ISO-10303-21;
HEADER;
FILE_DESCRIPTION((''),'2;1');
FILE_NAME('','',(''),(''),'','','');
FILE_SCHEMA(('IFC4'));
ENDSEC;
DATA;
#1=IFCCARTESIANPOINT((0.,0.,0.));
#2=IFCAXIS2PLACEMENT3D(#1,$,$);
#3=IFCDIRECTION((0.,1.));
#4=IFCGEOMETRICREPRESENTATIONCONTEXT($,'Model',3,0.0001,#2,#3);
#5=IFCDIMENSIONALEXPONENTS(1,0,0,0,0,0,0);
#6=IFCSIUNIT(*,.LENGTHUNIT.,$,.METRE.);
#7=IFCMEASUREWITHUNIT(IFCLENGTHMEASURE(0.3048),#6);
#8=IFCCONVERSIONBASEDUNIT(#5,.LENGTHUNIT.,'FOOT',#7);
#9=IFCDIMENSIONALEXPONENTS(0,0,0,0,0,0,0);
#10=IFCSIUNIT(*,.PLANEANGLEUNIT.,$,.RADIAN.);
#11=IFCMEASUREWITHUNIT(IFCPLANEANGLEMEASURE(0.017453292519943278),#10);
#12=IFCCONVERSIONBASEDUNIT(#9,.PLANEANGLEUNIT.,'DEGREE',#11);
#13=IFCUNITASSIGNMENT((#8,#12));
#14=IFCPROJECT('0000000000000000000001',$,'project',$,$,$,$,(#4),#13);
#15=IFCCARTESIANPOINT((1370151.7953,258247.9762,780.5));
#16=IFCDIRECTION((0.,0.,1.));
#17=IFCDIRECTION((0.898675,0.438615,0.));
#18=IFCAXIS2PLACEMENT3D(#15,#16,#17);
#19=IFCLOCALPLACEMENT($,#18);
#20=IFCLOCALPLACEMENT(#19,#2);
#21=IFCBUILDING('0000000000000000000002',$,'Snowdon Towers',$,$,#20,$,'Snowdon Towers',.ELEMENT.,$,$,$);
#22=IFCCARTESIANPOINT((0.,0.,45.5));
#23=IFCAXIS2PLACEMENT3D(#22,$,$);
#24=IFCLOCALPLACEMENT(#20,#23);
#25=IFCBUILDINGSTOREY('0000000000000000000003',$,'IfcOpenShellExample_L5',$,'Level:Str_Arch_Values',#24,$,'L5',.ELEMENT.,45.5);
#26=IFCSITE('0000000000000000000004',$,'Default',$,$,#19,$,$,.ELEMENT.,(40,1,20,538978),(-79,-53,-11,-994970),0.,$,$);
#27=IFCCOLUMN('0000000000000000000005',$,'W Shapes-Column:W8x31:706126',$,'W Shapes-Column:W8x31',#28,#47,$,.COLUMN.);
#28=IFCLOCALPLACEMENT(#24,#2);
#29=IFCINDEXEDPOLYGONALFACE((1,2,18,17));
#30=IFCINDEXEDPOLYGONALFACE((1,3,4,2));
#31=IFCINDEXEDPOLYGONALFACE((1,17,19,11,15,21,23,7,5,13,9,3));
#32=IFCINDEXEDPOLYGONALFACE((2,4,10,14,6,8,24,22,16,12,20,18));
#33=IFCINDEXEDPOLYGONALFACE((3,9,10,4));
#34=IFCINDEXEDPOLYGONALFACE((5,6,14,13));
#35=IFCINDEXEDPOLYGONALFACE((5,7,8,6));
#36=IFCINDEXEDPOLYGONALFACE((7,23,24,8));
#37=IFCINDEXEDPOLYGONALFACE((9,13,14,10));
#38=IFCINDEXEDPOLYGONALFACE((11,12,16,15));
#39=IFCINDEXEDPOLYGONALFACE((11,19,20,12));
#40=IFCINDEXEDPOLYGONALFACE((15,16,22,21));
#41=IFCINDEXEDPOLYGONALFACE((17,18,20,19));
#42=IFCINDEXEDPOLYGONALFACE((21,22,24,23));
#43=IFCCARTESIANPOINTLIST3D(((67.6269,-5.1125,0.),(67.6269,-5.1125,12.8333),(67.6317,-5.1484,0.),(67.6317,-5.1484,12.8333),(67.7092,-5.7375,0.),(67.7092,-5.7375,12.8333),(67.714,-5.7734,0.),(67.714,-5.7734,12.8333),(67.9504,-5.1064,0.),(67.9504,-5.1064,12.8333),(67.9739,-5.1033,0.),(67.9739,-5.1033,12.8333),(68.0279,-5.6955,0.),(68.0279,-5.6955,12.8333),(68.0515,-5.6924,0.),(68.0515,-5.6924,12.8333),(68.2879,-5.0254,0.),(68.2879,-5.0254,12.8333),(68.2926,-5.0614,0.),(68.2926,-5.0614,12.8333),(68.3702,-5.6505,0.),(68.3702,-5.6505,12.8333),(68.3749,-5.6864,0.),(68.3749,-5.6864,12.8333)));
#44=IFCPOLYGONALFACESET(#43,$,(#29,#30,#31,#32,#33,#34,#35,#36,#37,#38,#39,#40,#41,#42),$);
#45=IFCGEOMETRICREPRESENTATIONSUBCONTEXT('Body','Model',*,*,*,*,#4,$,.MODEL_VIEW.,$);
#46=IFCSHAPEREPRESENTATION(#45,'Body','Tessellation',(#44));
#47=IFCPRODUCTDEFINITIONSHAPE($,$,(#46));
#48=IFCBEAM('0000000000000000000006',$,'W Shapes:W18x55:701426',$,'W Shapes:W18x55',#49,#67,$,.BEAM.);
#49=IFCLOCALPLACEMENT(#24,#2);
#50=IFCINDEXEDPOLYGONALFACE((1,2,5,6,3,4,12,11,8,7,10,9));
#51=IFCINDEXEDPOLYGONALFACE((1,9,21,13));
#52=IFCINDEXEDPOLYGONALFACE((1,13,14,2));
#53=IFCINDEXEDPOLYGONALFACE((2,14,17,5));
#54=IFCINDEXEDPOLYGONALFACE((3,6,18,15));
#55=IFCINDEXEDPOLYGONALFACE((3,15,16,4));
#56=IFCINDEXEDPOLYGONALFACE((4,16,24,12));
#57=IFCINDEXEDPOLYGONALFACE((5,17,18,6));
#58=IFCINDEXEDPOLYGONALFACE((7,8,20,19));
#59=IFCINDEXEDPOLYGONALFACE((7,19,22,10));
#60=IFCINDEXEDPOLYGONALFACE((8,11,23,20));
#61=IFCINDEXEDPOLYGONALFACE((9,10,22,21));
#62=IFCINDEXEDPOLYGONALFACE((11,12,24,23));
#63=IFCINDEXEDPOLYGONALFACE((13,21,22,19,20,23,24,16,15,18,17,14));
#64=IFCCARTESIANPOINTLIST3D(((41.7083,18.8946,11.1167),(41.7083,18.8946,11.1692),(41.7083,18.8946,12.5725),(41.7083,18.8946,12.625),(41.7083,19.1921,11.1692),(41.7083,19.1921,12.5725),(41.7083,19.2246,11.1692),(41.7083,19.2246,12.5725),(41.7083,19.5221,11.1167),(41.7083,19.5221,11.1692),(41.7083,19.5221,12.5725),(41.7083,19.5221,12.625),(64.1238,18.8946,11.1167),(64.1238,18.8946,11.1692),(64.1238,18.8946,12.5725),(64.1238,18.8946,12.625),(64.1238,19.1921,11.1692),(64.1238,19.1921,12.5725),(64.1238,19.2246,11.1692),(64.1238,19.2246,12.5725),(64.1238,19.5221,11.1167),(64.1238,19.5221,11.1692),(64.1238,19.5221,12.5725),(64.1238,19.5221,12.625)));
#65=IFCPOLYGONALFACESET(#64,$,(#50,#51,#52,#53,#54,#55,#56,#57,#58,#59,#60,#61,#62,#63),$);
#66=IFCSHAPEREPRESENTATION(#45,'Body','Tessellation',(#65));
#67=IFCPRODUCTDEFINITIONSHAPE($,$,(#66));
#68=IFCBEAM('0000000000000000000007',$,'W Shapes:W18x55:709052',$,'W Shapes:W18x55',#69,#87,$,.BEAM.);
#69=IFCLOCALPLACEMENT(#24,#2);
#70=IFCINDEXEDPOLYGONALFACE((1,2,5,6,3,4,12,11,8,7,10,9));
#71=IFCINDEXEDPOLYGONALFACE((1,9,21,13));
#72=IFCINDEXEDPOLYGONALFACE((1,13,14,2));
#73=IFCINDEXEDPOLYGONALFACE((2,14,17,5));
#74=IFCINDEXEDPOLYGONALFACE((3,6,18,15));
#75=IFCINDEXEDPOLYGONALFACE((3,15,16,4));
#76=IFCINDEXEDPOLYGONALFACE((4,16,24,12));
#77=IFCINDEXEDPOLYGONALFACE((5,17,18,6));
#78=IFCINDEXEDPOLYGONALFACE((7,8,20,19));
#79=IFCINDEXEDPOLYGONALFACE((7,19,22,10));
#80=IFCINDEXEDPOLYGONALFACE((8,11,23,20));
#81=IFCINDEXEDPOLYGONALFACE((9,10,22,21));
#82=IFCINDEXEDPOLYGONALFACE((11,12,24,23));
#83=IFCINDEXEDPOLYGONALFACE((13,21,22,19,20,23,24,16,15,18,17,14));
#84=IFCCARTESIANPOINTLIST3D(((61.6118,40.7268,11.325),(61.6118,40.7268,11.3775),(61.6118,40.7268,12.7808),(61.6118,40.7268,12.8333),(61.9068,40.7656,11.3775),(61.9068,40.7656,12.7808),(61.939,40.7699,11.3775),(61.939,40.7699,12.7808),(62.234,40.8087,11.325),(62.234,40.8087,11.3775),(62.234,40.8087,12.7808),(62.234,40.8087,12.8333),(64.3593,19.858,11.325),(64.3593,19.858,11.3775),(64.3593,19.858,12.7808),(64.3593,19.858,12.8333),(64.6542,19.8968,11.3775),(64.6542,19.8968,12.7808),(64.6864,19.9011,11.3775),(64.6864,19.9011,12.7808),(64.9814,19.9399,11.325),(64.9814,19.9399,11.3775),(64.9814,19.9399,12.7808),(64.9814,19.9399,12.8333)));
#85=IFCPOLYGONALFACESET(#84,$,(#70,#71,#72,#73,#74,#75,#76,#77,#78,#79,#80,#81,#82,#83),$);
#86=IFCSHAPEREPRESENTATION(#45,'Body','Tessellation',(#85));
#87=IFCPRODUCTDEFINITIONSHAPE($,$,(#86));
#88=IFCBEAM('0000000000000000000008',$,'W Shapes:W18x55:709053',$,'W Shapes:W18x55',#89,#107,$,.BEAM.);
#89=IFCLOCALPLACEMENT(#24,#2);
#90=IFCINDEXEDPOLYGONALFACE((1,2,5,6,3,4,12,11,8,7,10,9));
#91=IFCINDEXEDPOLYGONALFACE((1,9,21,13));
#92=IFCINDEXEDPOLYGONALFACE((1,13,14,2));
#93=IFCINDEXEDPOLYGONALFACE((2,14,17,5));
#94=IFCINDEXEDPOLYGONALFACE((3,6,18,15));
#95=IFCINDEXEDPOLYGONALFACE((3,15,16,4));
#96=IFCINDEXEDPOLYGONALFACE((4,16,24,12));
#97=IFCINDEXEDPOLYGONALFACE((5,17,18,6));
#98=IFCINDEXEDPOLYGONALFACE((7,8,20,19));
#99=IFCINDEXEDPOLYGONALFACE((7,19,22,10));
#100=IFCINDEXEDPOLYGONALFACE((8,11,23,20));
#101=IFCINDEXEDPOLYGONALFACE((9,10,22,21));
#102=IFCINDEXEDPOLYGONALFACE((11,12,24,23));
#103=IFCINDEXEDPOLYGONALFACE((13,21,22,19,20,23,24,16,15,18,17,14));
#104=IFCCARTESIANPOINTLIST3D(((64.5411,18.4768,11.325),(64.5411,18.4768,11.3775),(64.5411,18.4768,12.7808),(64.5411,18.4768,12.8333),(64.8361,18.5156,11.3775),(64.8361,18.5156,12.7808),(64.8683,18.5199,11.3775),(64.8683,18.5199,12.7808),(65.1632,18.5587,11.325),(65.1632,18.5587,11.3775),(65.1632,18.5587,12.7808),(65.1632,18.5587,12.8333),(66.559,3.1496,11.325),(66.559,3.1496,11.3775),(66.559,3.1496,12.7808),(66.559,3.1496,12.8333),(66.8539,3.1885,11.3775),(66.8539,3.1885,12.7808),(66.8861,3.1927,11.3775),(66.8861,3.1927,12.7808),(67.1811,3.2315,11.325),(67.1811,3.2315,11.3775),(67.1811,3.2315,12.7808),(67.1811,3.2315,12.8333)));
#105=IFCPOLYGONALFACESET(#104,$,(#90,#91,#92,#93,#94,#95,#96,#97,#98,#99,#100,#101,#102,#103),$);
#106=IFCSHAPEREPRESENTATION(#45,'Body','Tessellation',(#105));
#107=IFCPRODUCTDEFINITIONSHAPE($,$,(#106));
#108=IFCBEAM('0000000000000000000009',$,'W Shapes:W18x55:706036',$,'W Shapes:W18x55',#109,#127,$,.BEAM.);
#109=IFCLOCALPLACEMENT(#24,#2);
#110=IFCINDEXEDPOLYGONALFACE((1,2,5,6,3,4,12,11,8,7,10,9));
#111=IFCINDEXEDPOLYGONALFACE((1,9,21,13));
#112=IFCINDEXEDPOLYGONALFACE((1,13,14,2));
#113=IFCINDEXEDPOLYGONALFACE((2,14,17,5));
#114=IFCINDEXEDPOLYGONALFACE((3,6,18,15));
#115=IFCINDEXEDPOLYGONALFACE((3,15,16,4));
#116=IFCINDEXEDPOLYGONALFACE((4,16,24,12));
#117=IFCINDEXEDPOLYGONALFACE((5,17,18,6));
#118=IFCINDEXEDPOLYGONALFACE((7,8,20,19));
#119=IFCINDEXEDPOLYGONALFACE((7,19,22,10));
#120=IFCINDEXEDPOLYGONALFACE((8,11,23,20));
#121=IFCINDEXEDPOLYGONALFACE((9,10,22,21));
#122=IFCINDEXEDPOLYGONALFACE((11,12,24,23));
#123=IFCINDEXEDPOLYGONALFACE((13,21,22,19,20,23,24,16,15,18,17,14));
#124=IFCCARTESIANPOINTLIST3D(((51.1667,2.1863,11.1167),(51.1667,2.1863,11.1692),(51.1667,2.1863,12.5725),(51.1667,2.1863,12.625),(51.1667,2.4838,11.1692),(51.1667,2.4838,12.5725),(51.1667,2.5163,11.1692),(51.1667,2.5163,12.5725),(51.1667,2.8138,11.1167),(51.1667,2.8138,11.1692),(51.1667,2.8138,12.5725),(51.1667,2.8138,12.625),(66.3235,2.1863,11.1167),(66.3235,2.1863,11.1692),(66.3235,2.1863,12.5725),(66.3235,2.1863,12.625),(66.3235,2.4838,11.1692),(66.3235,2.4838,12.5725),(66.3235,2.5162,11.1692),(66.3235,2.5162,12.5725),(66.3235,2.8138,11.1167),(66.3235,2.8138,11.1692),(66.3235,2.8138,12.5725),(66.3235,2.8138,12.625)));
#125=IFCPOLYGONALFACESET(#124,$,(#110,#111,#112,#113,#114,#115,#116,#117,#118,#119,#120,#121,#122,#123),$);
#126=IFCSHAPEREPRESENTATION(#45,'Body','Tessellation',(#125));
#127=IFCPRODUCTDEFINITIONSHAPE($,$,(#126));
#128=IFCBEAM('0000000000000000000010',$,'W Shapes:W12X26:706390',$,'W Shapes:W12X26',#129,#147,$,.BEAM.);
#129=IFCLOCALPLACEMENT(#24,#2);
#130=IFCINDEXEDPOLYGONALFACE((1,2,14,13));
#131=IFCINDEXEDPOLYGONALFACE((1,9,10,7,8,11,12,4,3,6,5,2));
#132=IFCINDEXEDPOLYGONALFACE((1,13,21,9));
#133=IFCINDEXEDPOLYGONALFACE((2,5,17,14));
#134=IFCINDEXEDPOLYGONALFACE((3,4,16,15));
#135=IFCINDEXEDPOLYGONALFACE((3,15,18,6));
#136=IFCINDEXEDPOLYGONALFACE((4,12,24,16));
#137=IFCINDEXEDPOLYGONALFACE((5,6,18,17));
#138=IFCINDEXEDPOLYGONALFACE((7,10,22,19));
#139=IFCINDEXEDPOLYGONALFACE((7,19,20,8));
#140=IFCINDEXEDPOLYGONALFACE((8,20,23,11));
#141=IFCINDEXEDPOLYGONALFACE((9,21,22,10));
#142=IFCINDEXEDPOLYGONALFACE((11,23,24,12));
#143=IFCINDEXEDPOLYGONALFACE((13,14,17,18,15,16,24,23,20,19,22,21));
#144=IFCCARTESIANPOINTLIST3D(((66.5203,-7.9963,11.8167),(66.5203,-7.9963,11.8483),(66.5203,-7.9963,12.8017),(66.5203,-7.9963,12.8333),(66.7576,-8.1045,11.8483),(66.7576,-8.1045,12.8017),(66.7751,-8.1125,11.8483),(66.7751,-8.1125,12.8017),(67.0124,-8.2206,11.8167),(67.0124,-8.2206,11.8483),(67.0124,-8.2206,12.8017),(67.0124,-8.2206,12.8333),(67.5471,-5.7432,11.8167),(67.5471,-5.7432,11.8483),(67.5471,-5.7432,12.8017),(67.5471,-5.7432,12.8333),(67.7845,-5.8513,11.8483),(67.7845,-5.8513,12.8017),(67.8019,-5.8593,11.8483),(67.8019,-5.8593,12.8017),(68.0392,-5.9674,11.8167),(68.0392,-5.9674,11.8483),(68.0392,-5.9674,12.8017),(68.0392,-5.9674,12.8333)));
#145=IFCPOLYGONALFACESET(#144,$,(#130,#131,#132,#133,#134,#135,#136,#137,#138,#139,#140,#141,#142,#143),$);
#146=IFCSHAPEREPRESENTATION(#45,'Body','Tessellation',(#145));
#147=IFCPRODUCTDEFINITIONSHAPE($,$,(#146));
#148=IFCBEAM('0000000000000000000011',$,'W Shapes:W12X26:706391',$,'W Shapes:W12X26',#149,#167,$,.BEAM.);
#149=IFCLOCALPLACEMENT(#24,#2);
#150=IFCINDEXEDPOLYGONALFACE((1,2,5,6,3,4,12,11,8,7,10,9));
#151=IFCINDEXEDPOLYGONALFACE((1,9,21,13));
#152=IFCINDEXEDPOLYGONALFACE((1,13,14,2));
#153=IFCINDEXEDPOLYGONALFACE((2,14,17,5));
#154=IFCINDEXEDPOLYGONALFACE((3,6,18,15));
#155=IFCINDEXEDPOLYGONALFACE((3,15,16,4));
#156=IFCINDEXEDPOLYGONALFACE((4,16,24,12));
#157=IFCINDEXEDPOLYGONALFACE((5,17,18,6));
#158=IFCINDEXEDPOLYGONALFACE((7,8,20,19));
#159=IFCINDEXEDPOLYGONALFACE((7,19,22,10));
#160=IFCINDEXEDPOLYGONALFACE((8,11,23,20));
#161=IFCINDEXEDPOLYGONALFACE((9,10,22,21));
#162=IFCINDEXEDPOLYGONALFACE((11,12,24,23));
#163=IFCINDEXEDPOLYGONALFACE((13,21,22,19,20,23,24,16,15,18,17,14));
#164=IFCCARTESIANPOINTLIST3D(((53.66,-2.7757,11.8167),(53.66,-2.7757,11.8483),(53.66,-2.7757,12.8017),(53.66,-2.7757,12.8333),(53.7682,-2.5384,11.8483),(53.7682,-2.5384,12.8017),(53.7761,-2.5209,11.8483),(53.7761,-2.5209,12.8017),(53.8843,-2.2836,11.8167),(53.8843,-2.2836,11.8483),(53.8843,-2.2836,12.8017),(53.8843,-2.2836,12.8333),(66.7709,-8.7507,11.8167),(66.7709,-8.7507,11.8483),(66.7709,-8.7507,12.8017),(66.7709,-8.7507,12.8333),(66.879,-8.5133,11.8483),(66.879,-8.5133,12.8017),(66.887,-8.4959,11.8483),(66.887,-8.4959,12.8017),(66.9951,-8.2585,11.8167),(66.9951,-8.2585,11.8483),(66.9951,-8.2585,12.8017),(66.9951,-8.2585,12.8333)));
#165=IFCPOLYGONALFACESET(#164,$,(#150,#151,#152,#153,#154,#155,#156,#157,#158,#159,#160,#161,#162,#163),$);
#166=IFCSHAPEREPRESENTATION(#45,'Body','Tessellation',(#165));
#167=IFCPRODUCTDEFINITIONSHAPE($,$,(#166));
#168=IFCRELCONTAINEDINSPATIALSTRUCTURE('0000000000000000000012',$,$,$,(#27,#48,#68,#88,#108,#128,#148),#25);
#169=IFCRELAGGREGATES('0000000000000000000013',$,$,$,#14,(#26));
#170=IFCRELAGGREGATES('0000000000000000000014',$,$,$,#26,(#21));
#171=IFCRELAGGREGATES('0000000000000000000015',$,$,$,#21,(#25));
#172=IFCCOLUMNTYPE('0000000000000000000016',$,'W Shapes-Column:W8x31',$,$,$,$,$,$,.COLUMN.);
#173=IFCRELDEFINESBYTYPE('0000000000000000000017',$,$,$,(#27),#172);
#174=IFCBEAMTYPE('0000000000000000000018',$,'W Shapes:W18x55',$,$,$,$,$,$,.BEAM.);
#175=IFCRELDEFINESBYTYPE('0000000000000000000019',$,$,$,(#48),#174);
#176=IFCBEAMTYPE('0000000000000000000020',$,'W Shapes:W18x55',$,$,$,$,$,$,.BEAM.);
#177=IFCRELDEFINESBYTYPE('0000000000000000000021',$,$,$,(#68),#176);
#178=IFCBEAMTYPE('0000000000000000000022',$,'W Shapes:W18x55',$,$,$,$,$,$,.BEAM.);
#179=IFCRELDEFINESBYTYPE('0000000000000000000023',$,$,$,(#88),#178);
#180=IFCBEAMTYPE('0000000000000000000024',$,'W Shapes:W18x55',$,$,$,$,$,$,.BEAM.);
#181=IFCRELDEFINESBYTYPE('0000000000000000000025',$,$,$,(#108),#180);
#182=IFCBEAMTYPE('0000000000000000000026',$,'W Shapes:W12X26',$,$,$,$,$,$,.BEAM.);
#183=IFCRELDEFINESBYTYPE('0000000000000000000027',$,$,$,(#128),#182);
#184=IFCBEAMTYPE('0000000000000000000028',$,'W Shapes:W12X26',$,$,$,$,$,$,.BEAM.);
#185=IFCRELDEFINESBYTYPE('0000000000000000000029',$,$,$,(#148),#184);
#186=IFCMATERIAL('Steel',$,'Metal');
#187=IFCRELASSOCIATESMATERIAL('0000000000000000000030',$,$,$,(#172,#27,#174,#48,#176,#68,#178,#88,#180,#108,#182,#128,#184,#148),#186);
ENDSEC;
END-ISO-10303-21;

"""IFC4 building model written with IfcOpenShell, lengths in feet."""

from ifc_helpers import new_model, entity, si_unit, converted_unit, direction, frame, origin, place, context, subcontext, project, spatial, indexed_curve, outline, extrude, source, transform, mapped, material, type_object, type_shapes, element, save


model = new_model("IFC4")

# Units and contexts
model_context = context("Model", 3, precision=0.0001, world=origin(), true_north=direction((0.0, 1.0)))
body_context = subcontext(model_context, "Body", "Model", "MODEL_VIEW")
ifc_project = project(units=[converted_unit("LENGTHUNIT", "FOOT", entity("IfcLengthMeasure", 0.3048), si_unit("LENGTHUNIT", "METRE"), dimensions=[1, 0, 0, 0, 0, 0, 0]), converted_unit("PLANEANGLEUNIT", "DEGREE", entity("IfcPlaneAngleMeasure", 0.017453292519943278), si_unit("PLANEANGLEUNIT", "RADIAN"), dimensions=[0, 0, 0, 0, 0, 0, 0])], contexts=[model_context])

# Site, building, storey
site_placement = place(None, frame((1370151.7953, 258247.9762, 780.5), z_axis=(0.0, 0.0, 1.0), x_axis=(0.898675, 0.438615, 0.0)))
site = spatial("IfcSite", under=ifc_project, at=site_placement, Name="Default", CompositionType="ELEMENT", RefLatitude=(40, 1, 20, 538978), RefLongitude=(-79, -53, -11, -994970), RefElevation=0.0)
building_placement = place(site_placement, origin())
building = spatial("IfcBuilding", under=site, at=building_placement, Name="Snowdon Towers", LongName="Snowdon Towers", CompositionType="ELEMENT")
storey_placement = place(building_placement, frame((0.0, 0.0, 45.5)))
storey = spatial("IfcBuildingStorey", under=building, at=storey_placement, Name="IfcOpenShellExample_L5", ObjectType="Level:Str_Arch_Values", LongName="L5", CompositionType="ELEMENT", Elevation=45.5)

# Column
ifc_material = material(Name="Steel", Category="Metal")
column_type = type_object("IfcColumnType", Name="W Shapes-Column:W8x31", PredefinedType="COLUMN", material=ifc_material)
shared_shape_1 = source(origin(), body_context, "Body", "SweptSolid", [
    extrude(outline(indexed_curve([(-0.3333, -0.3333), (0.3333, -0.3333), (0.3333, -0.2971), (0.0119, -0.2971), (0.0119, 0.2971), (0.3333, 0.2971), (0.3333, 0.3333), (-0.3333, 0.3333), (-0.3333, 0.2971), (-0.0119, 0.2971), (-0.0119, -0.2971), (-0.3333, -0.2971), (-0.3333, -0.3333)], self_intersect=False)), frame((0.0, 0.0, 45.5), z_axis=(0.0, 0.0, 1.0), x_axis=(-1.0, 0.0, 0.0)), (0.0, 0.0, 1.0), 12.8333),
])
type_shapes(column_type, [shared_shape_1])
column_placement = place(storey_placement, frame((68.0009, -5.3994, -45.5), z_axis=(0.0, 0.0, 1.0), x_axis=(0.991445, 0.130526, 0.0)))
element("IfcColumn", 1, at=column_placement, inside=storey, type_object=column_type, material=ifc_material, Name="W Shapes-Column:W8x31:706126", ObjectType="W Shapes-Column:W8x31", PredefinedType="COLUMN", context=body_context, shape_type="MappedRepresentation", body=[
    mapped(shared_shape_1, transform((0.0, 0.0, 0.0), scale=1.0)),
])

# Beams
beam_type_1 = type_object("IfcBeamType", Name="W Shapes:W18x55", PredefinedType="BEAM", material=ifc_material)
shared_shape_2 = source(origin(), body_context, "Body", "SweptSolid", [
    extrude(outline(indexed_curve([(-0.3138, -0.7017), (-0.3138, -0.7542), (0.3138, -0.7542), (0.3138, -0.7017), (0.0162, -0.7017), (0.0162, 0.7017), (0.3138, 0.7017), (0.3138, 0.7542), (-0.3137, 0.7542), (-0.3137, 0.7017), (-0.0163, 0.7017), (-0.0163, -0.7017), (-0.3138, -0.7017)], self_intersect=False)), frame((-11.5915, 0.0, 0.0), z_axis=(-1.0, 0.0, 0.0), x_axis=(0.0, -1.0, 0.0)), (0.0, 0.0, -1.0), 22.4154),
])
type_shapes(beam_type_1, [shared_shape_2])
beam_1_placement = place(storey_placement, frame((53.2998, 19.2083, 11.8708)))
element("IfcBeam", 2, at=beam_1_placement, inside=storey, type_object=beam_type_1, material=ifc_material, Name="W Shapes:W18x55:701426", ObjectType="W Shapes:W18x55", PredefinedType="BEAM", context=body_context, shape_type="MappedRepresentation", body=[
    mapped(shared_shape_2, transform((0.0, 0.0, 0.0), scale=1.0)),
])
beam_type_2 = type_object("IfcBeamType", Name="W Shapes:W18x55", PredefinedType="BEAM", material=ifc_material)
shared_shape_3 = source(origin(), body_context, "Body", "SweptSolid", [
    extrude(outline(indexed_curve([(-0.3138, -0.7017), (-0.3138, -0.7542), (0.3138, -0.7542), (0.3138, -0.7017), (0.0162, -0.7017), (0.0162, 0.7017), (0.3138, 0.7017), (0.3138, 0.7542), (-0.3137, 0.7542), (-0.3137, 0.7017), (-0.0163, 0.7017), (-0.0163, -0.7017), (-0.3138, -0.7017)], self_intersect=False)), frame((-10.5172, 0.0, 0.0), z_axis=(-1.0, 0.0, 0.0), x_axis=(0.0, -1.0, 0.0)), (0.0, 0.0, -1.0), 21.0489),
])
type_shapes(beam_type_2, [shared_shape_3])
beam_2_placement = place(storey_placement, frame((63.2957, 30.3405, 12.0792), z_axis=(0.0, 0.0, 1.0), x_axis=(0.130526, -0.991445, 0.0)))
element("IfcBeam", 3, at=beam_2_placement, inside=storey, type_object=beam_type_2, material=ifc_material, Name="W Shapes:W18x55:709052", ObjectType="W Shapes:W18x55", PredefinedType="BEAM", context=body_context, shape_type="MappedRepresentation", body=[
    mapped(shared_shape_3, transform((0.0, 0.0, 0.0), scale=1.0)),
])
beam_type_3 = type_object("IfcBeamType", Name="W Shapes:W18x55", PredefinedType="BEAM", material=ifc_material)
shared_shape_4 = source(origin(), body_context, "Body", "SweptSolid", [
    extrude(outline(indexed_curve([(-0.3138, -0.7017), (-0.3138, -0.7542), (0.3138, -0.7542), (0.3138, -0.7017), (0.0162, -0.7017), (0.0162, 0.7017), (0.3138, 0.7017), (0.3138, 0.7542), (-0.3137, 0.7542), (-0.3137, 0.7017), (-0.0163, 0.7017), (-0.0163, -0.7017), (-0.3138, -0.7017)], self_intersect=False)), frame((-7.8065, 0.0, 0.0), z_axis=(-1.0, 0.0, 0.0), x_axis=(0.0, -1.0, 0.0)), (0.0, 0.0, -1.0), 15.4594),
])
type_shapes(beam_type_3, [shared_shape_4])
beam_3_placement = place(storey_placement, frame((65.8711, 10.778, 12.0792), z_axis=(0.0, 0.0, 1.0), x_axis=(0.130526, -0.991445, 0.0)))
element("IfcBeam", 4, at=beam_3_placement, inside=storey, type_object=beam_type_3, material=ifc_material, Name="W Shapes:W18x55:709053", ObjectType="W Shapes:W18x55", PredefinedType="BEAM", context=body_context, shape_type="MappedRepresentation", body=[
    mapped(shared_shape_4, transform((0.0, 0.0, 0.0), scale=1.0)),
])
beam_type_4 = type_object("IfcBeamType", Name="W Shapes:W18x55", PredefinedType="BEAM", material=ifc_material)
shared_shape_5 = source(origin(), body_context, "Body", "SweptSolid", [
    extrude(outline(indexed_curve([(-0.3138, -0.7017), (-0.3138, -0.7542), (0.3138, -0.7542), (0.3138, -0.7017), (0.0162, -0.7017), (0.0162, 0.7017), (0.3138, 0.7017), (0.3138, 0.7542), (-0.3137, 0.7542), (-0.3137, 0.7017), (-0.0163, 0.7017), (-0.0163, -0.7017), (-0.3138, -0.7017)], self_intersect=False)), frame((-7.2596, 0.0, 0.0), z_axis=(-1.0, 0.0, 0.0), x_axis=(0.0, -1.0, 0.0)), (0.0, 0.0, -1.0), 15.1568),
])
type_shapes(beam_type_4, [shared_shape_5])
beam_4_placement = place(storey_placement, frame((59.0638, 2.5, 11.8708), z_axis=(0.0, 0.0, 1.0), x_axis=(-1.0, 0.0, 0.0)))
element("IfcBeam", 5, at=beam_4_placement, inside=storey, type_object=beam_type_4, material=ifc_material, Name="W Shapes:W18x55:706036", ObjectType="W Shapes:W18x55", PredefinedType="BEAM", context=body_context, shape_type="MappedRepresentation", body=[
    mapped(shared_shape_5, transform((0.0, 0.0, 0.0), scale=1.0)),
])
beam_type_5 = type_object("IfcBeamType", Name="W Shapes:W12X26", PredefinedType="BEAM", material=ifc_material)
shared_shape_6 = source(origin(), body_context, "Body", "SweptSolid", [
    extrude(outline(indexed_curve([(-0.2704, -0.4767), (-0.2704, -0.5083), (0.2704, -0.5083), (0.2704, -0.4767), (0.0096, -0.4767), (0.0096, 0.4767), (0.2704, 0.4767), (0.2704, 0.5083), (-0.2704, 0.5083), (-0.2704, 0.4767), (-0.0096, 0.4767), (-0.0096, -0.4767), (-0.2704, -0.4767)], self_intersect=False)), frame((-1.3325, 0.0, 0.0), z_axis=(-1.0, 0.0, 0.0), x_axis=(0.0, -1.0, 0.0)), (0.0, 0.0, -1.0), 2.4761),
])
type_shapes(beam_type_5, [shared_shape_6])
beam_5_placement = place(storey_placement, frame((67.3189, -6.8959, 12.325), z_axis=(0.0, 0.0, 1.0), x_axis=(0.414693, 0.909961, 0.0)))
element("IfcBeam", 6, at=beam_5_placement, inside=storey, type_object=beam_type_5, material=ifc_material, Name="W Shapes:W12X26:706390", ObjectType="W Shapes:W12X26", PredefinedType="BEAM", context=body_context, shape_type="MappedRepresentation", body=[
    mapped(shared_shape_6, transform((0.0, 0.0, 0.0), scale=1.0)),
])
beam_type_6 = type_object("IfcBeamType", Name="W Shapes:W12X26", PredefinedType="BEAM", material=ifc_material)
shared_shape_7 = source(origin(), body_context, "Body", "SweptSolid", [
    extrude(outline(indexed_curve([(-0.2704, -0.4767), (-0.2704, -0.5083), (0.2704, -0.5083), (0.2704, -0.4767), (0.0096, -0.4767), (0.0096, 0.4767), (0.2704, 0.4767), (0.2704, 0.5083), (-0.2704, 0.5083), (-0.2704, 0.4767), (-0.0096, 0.4767), (-0.0096, -0.4767), (-0.2704, -0.4767)], self_intersect=False)), frame((-7.0689, 0.0, 0.0), z_axis=(-1.0, 0.0, 0.0), x_axis=(0.0, -1.0, 0.0)), (0.0, 0.0, -1.0), 14.4081),
])
type_shapes(beam_type_6, [shared_shape_7])
beam_6_placement = place(storey_placement, frame((60.2045, -5.4611, 12.325), z_axis=(0.0, 0.0, 1.0), x_axis=(0.909961, -0.414693, 0.0)))
element("IfcBeam", 7, at=beam_6_placement, inside=storey, type_object=beam_type_6, material=ifc_material, Name="W Shapes:W12X26:706391", ObjectType="W Shapes:W12X26", PredefinedType="BEAM", context=body_context, shape_type="MappedRepresentation", body=[
    mapped(shared_shape_7, transform((0.0, 0.0, 0.0), scale=1.0)),
])

save(model, "model.ifc")
